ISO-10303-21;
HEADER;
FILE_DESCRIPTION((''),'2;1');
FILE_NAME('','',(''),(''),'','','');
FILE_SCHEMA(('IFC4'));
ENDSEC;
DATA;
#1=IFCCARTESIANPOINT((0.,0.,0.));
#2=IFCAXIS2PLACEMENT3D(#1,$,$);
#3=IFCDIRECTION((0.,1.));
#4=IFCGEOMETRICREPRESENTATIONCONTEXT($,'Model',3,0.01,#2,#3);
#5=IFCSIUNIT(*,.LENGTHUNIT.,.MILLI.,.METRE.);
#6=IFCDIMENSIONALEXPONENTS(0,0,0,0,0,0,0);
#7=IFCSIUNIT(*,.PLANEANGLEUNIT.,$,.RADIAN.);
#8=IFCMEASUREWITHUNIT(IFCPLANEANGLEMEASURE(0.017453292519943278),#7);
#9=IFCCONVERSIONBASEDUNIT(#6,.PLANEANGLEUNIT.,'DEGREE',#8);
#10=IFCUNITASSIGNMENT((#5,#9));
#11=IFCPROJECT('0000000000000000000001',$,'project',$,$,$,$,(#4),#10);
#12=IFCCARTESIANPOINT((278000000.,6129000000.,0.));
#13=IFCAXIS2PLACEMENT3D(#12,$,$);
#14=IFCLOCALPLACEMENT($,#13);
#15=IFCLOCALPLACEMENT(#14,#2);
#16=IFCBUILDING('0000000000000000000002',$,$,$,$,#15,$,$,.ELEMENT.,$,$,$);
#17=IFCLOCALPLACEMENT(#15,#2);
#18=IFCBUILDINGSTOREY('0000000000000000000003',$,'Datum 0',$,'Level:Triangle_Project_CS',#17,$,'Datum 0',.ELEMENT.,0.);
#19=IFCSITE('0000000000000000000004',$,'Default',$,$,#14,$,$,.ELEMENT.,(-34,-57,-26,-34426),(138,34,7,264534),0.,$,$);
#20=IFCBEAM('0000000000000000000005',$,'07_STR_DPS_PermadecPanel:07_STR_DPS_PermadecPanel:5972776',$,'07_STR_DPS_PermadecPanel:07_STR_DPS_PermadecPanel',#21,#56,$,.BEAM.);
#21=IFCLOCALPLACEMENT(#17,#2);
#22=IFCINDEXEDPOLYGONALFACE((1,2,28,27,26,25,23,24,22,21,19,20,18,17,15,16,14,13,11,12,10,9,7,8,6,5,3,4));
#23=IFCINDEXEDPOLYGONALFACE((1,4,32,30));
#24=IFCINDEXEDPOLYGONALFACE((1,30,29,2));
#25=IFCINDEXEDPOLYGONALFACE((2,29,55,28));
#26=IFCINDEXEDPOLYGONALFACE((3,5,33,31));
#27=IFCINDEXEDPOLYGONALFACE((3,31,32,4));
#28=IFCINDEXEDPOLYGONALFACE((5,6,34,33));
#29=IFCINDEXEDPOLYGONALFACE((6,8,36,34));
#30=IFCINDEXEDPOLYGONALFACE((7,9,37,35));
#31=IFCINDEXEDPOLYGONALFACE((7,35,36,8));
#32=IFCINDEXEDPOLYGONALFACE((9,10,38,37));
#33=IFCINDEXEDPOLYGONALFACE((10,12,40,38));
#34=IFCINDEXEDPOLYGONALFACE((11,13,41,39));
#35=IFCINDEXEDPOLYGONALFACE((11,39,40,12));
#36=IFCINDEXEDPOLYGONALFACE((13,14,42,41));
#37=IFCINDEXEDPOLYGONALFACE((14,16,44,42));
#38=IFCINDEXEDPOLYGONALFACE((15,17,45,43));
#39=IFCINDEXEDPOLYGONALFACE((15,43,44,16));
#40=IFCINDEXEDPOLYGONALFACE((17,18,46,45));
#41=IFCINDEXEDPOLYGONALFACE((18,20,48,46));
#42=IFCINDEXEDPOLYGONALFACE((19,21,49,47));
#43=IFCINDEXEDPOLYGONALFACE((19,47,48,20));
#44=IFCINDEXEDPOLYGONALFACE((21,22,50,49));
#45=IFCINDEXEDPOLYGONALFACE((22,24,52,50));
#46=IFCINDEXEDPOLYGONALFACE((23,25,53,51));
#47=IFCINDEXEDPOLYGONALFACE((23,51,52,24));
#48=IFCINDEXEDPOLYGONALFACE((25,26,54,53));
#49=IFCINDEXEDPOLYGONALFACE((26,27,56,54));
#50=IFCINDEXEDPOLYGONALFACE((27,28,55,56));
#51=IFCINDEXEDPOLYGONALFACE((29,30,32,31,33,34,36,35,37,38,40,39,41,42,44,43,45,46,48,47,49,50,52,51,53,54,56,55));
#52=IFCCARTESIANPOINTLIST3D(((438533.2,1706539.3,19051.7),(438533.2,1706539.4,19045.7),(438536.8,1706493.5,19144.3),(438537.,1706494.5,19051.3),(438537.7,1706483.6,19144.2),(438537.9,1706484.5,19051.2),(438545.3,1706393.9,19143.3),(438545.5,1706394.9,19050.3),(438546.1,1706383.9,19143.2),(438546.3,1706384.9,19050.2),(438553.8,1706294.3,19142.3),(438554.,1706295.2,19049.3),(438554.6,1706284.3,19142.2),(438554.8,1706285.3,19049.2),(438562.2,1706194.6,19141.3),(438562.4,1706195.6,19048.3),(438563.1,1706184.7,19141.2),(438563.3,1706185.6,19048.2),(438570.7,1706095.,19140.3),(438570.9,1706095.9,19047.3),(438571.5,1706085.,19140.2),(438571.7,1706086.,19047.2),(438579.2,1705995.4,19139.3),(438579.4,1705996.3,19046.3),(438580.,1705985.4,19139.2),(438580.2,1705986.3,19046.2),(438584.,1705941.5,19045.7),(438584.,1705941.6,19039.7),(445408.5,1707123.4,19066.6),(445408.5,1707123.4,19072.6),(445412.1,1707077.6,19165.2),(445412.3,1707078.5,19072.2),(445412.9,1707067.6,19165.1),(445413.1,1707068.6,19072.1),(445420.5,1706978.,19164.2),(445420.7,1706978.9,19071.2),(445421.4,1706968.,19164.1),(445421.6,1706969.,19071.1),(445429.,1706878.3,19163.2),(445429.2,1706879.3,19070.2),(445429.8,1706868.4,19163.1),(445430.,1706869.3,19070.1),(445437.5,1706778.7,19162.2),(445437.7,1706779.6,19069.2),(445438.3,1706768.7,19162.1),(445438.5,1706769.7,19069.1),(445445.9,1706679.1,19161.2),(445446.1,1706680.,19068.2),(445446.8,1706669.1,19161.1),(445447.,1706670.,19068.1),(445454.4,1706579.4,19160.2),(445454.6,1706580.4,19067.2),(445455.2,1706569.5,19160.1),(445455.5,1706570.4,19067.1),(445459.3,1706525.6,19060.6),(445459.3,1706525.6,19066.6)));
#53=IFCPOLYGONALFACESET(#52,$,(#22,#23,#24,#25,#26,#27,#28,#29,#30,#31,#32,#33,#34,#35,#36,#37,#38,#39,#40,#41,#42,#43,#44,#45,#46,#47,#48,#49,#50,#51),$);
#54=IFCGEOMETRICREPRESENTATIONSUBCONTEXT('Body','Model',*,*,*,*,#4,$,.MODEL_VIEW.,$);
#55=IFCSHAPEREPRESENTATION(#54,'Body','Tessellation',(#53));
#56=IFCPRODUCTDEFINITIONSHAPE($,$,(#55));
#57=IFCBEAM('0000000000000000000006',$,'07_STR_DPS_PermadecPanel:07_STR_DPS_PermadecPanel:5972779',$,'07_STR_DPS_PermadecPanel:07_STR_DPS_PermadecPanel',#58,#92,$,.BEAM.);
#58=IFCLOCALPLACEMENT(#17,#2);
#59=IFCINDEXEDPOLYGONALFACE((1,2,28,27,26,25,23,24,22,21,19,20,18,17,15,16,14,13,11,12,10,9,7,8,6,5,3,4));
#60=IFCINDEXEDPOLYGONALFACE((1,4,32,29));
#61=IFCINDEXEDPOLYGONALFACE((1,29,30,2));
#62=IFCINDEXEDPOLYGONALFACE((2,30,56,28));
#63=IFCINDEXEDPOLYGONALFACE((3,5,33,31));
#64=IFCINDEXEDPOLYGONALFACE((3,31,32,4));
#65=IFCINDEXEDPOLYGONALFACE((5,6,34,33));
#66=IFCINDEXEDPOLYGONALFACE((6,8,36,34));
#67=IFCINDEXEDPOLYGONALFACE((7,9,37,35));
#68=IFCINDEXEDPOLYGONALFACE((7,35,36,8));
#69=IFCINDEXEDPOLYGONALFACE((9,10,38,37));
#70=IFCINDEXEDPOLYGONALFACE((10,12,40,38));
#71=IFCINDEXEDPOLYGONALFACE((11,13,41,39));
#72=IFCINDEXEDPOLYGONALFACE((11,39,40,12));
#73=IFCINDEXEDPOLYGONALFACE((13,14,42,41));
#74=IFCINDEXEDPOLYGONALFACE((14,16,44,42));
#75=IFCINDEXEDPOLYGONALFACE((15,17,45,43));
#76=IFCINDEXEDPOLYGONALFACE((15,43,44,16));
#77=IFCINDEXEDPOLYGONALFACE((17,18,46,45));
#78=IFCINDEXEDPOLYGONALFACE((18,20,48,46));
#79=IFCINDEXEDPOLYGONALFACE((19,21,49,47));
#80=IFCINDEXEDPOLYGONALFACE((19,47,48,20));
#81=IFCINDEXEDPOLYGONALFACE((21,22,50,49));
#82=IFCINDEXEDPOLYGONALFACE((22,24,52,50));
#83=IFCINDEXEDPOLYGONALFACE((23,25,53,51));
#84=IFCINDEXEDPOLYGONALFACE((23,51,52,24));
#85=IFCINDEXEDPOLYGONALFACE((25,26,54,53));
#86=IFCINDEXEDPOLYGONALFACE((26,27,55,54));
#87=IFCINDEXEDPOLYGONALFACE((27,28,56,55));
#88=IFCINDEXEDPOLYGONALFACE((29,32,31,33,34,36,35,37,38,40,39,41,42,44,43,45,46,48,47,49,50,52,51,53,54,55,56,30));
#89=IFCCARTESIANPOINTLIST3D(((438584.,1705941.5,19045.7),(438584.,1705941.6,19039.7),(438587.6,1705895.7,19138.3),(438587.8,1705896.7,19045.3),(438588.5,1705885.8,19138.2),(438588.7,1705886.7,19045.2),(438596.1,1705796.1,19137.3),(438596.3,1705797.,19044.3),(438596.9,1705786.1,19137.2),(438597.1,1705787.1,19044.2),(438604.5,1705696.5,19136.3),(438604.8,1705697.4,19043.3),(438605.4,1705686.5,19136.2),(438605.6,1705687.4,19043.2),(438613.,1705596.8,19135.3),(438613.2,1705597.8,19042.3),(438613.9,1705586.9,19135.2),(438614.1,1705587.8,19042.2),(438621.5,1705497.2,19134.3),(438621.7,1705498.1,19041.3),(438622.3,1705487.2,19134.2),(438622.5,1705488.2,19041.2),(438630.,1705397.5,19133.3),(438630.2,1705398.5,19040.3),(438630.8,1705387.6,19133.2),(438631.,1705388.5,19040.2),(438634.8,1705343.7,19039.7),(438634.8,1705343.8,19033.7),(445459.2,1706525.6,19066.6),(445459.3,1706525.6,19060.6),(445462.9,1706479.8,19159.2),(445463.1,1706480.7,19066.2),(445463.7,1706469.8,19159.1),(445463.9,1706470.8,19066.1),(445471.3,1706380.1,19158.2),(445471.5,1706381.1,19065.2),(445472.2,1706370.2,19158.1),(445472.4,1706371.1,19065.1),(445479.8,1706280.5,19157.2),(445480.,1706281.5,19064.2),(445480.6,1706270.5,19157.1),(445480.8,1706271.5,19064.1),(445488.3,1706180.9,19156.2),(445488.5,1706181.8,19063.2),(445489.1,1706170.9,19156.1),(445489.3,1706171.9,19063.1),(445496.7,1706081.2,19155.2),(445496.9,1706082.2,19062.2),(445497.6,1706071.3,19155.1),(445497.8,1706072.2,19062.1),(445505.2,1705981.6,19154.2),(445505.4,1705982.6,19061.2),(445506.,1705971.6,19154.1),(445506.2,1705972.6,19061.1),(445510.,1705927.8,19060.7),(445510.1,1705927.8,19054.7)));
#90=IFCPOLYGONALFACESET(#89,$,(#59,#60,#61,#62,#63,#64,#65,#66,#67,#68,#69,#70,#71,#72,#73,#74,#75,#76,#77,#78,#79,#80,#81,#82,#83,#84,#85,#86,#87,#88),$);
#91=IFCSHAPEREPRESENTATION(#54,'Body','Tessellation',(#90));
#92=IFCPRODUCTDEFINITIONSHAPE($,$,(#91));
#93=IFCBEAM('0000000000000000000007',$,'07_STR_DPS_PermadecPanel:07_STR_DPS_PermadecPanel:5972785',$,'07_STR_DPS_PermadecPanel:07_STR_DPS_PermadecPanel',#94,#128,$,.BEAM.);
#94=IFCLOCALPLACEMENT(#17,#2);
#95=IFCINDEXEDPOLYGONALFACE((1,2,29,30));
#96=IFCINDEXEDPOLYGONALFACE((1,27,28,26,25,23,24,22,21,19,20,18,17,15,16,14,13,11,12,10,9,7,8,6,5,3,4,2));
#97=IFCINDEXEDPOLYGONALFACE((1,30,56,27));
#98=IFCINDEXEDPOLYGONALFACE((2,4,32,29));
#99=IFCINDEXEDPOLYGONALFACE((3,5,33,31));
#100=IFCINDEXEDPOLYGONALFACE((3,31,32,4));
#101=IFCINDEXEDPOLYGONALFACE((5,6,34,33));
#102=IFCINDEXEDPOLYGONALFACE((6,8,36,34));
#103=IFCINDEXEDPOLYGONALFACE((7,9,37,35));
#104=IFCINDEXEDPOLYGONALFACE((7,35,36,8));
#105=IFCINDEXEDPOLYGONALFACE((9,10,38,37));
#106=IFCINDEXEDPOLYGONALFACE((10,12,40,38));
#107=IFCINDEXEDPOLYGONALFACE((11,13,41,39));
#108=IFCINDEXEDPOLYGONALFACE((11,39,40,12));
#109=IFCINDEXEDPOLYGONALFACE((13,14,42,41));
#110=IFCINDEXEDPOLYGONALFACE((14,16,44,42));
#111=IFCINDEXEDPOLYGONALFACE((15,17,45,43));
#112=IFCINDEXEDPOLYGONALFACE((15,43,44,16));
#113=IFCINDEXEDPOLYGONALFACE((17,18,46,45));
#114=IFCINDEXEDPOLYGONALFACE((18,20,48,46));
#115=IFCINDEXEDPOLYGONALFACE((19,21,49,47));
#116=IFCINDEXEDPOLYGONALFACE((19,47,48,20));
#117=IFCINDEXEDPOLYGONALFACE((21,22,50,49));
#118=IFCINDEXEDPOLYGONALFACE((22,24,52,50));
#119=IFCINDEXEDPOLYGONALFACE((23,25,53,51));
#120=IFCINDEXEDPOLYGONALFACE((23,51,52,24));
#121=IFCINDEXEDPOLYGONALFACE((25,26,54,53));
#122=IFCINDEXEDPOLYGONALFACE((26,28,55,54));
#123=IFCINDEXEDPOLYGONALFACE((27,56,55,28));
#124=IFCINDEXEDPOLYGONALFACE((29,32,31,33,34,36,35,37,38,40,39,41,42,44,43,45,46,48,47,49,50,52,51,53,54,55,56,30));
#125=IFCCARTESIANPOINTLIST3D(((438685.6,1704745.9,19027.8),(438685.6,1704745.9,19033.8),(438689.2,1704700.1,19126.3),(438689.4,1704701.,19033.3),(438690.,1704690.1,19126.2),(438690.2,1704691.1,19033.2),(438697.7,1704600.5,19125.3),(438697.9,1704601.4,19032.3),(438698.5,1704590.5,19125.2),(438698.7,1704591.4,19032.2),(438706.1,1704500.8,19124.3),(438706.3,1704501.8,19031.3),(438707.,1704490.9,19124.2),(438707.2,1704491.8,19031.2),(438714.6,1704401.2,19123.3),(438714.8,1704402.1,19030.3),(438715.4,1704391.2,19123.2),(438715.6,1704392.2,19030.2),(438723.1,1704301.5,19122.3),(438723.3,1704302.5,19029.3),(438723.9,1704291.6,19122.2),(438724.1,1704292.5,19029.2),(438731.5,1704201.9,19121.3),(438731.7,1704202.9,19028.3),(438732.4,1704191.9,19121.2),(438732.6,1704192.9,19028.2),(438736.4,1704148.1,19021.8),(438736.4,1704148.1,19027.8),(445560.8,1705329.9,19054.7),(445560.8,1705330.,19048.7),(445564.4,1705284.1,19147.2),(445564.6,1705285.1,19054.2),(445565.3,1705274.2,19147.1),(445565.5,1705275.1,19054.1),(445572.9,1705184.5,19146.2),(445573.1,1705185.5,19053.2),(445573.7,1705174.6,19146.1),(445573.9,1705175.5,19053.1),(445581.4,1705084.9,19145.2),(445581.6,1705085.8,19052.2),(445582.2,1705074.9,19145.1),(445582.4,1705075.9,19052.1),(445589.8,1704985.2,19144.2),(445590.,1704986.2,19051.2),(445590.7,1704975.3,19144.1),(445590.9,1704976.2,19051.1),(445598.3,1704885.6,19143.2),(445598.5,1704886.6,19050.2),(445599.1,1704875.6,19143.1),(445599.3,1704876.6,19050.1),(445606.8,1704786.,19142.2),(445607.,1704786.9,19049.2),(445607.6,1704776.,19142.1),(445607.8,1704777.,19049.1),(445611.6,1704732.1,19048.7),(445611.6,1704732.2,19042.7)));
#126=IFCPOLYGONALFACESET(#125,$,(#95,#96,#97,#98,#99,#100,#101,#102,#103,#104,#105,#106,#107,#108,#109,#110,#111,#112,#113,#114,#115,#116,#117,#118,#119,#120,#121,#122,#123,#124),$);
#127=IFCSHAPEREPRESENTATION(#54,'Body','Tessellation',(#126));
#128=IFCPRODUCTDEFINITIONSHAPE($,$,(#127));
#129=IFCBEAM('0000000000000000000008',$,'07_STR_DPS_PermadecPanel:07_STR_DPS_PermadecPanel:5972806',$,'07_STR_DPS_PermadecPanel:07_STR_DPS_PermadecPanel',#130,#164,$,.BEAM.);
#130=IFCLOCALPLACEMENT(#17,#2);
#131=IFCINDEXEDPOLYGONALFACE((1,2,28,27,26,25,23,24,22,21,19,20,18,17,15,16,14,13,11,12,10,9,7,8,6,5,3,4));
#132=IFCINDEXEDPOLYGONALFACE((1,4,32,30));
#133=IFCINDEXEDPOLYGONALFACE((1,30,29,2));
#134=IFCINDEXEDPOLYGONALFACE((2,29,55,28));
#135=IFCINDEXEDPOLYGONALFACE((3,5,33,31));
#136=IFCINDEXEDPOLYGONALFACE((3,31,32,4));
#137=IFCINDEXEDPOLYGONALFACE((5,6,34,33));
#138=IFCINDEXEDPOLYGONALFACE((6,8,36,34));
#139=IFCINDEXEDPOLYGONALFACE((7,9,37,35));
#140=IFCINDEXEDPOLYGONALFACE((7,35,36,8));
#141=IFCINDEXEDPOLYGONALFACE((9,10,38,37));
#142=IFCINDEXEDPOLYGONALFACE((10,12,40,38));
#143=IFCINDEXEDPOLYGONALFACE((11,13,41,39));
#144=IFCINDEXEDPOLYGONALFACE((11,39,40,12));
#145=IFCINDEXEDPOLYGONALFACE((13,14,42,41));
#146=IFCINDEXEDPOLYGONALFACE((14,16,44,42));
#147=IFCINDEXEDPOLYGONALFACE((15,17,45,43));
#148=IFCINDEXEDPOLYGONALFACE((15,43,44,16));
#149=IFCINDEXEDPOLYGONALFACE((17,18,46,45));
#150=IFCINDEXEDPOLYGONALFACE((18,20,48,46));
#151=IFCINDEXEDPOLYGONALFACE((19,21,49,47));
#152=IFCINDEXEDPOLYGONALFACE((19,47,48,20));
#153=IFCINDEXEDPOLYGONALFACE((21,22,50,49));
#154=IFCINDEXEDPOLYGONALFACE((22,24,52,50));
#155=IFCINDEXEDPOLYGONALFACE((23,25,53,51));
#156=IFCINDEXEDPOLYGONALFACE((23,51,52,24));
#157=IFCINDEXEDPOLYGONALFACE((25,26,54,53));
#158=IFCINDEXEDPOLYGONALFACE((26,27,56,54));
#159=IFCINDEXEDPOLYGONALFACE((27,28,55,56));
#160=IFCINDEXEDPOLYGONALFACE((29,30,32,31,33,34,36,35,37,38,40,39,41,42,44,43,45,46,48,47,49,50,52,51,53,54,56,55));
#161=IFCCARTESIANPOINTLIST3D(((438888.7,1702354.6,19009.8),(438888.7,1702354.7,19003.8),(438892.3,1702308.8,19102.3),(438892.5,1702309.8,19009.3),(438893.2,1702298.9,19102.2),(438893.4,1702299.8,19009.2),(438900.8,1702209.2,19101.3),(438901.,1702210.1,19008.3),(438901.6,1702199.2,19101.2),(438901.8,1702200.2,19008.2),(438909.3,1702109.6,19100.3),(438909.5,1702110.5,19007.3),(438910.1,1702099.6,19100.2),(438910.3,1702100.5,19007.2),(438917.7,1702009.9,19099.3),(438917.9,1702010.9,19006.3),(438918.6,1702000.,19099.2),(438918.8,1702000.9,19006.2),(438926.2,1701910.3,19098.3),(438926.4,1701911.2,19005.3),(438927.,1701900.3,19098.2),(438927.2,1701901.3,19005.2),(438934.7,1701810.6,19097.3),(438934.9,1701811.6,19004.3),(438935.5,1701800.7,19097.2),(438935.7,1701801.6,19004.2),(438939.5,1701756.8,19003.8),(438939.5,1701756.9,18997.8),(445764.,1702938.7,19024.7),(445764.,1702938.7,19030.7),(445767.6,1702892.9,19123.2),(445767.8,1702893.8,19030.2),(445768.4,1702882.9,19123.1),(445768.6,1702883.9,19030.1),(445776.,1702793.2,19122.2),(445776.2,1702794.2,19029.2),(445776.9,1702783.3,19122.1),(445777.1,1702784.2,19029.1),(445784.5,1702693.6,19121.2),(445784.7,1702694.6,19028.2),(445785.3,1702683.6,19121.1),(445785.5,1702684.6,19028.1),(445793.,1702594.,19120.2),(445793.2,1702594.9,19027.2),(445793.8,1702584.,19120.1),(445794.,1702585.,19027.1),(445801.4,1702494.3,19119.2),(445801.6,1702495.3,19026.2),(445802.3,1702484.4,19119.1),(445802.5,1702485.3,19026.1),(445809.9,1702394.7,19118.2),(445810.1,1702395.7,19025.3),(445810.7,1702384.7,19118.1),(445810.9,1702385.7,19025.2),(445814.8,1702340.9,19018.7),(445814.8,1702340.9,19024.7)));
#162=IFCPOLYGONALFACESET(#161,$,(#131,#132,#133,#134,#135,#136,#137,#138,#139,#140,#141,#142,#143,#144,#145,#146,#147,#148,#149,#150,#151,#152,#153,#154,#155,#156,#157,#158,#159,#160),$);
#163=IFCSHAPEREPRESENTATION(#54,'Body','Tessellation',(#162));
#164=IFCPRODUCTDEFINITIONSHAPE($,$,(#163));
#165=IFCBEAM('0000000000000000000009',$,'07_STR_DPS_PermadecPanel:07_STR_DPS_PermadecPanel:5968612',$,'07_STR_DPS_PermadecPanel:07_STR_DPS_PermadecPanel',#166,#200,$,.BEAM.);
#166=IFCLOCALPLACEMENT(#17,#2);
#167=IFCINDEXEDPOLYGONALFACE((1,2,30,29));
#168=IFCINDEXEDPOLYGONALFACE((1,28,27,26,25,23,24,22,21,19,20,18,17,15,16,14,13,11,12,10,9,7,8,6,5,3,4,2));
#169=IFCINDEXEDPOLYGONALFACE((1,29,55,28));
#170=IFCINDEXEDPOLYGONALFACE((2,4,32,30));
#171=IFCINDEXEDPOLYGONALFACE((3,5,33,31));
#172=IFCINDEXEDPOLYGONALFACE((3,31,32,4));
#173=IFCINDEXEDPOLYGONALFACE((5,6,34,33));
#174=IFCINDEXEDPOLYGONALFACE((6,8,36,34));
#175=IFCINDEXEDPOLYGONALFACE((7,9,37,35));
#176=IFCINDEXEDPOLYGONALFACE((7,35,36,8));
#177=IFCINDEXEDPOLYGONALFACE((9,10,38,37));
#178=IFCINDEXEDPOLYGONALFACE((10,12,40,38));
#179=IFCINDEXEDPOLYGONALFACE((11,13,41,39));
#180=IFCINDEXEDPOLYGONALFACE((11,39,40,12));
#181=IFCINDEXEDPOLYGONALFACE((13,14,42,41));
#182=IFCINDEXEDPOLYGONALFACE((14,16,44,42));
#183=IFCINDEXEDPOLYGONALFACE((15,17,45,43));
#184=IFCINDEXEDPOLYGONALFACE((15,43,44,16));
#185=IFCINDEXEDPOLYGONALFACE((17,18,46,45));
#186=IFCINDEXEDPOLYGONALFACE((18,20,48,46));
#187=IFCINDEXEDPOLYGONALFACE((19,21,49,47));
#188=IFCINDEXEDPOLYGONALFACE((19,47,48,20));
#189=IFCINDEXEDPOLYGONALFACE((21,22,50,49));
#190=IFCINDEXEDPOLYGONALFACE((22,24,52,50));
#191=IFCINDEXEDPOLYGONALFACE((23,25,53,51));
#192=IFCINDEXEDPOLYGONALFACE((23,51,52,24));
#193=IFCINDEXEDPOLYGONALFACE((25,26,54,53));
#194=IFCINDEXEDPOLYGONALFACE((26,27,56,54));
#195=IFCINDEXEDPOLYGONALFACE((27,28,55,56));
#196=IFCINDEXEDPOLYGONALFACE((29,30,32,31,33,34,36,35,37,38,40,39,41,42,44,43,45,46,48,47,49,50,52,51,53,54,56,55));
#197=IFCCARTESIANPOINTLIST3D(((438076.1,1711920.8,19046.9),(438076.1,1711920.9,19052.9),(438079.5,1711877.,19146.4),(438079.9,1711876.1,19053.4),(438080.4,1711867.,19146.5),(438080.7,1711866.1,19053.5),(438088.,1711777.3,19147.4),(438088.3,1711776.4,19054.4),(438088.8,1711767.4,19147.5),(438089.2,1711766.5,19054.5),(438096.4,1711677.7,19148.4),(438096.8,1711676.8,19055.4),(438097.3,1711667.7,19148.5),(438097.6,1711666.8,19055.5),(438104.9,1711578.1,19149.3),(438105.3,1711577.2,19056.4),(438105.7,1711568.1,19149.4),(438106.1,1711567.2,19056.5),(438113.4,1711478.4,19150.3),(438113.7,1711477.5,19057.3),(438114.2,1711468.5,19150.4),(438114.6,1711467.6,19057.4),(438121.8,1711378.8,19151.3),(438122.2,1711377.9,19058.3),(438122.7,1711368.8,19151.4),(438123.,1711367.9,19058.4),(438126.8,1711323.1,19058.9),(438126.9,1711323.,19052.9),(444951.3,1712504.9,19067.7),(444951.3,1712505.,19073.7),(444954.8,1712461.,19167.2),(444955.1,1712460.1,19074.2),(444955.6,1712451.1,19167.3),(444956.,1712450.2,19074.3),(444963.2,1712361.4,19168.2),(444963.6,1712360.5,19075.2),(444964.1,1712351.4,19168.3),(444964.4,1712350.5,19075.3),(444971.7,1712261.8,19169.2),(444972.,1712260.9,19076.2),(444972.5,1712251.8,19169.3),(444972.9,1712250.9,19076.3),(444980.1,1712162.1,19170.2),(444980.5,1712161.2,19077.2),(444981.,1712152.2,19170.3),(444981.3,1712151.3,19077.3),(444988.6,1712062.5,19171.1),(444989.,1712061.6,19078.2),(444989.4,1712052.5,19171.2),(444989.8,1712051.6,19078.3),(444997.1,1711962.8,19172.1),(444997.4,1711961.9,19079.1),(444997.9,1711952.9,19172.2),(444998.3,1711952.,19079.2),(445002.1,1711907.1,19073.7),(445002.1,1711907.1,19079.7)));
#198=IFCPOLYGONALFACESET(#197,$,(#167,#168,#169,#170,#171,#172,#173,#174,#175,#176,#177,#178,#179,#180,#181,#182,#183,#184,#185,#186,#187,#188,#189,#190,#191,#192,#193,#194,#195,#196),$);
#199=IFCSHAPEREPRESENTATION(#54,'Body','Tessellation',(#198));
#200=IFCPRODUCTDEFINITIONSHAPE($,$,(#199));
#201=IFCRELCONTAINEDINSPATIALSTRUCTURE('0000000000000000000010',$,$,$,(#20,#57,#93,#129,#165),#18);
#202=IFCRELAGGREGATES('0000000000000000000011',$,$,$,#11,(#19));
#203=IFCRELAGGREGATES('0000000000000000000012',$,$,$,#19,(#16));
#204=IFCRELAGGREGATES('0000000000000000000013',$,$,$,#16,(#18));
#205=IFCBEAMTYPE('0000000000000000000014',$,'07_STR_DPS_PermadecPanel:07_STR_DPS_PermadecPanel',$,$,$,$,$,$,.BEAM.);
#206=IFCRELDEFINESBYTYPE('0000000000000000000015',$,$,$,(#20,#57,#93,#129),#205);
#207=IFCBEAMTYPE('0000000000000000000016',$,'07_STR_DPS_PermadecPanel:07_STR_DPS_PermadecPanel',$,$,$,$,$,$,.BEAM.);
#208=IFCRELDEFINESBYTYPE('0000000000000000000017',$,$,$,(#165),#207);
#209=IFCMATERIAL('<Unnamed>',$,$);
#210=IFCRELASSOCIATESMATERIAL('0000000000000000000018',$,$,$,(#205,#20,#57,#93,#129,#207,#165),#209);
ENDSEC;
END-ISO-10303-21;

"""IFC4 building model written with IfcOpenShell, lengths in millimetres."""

from ifc_helpers import new_model, entity, si_unit, converted_unit, direction, frame, origin, place, context, subcontext, project, spatial, indexed_curve, outline, extrude, source, transform, mapped, material, type_object, type_shapes, element, save


model = new_model("IFC4")

# Units and contexts
model_context = context("Model", 3, precision=0.01, world=origin(), true_north=direction((0.0, 1.0)))
body_context = subcontext(model_context, "Body", "Model", "MODEL_VIEW")
ifc_project = project(units=[si_unit("LENGTHUNIT", "METRE", prefix="MILLI"), converted_unit("PLANEANGLEUNIT", "DEGREE", entity("IfcPlaneAngleMeasure", 0.017453292519943278), si_unit("PLANEANGLEUNIT", "RADIAN"), dimensions=[0, 0, 0, 0, 0, 0, 0])], contexts=[model_context])

# Site, building, storey
site_placement = place(None, frame((278000000.0, 6129000000.0, 0.0)))
site = spatial("IfcSite", under=ifc_project, at=site_placement, Name="Default", CompositionType="ELEMENT", RefLatitude=(-34, -57, -26, -34426), RefLongitude=(138, 34, 7, 264534), RefElevation=0.0)
building_placement = place(site_placement, origin())
building = spatial("IfcBuilding", under=site, at=building_placement, CompositionType="ELEMENT")
storey_placement = place(building_placement, frame((0.0, 0.0, 0.0)))
storey = spatial("IfcBuildingStorey", under=building, at=storey_placement, Name="Datum 0", ObjectType="Level:Triangle_Project_CS", LongName="Datum 0", CompositionType="ELEMENT", Elevation=0.0)

# Beams
ifc_material = material(Name="<Unnamed>")
beam_type_1 = type_object("IfcBeamType", Name="07_STR_DPS_PermadecPanel:07_STR_DPS_PermadecPanel", PredefinedType="BEAM", material=ifc_material)
shared_shape_1 = source(origin(), body_context, "Body", "SweptSolid", [
    extrude(outline(indexed_curve([(-300.0, -45.4), (300.0, -45.4), (300.0, -39.4), (255.0, -39.4), (255.0, 53.6), (245.0, 53.6), (245.0, -39.4), (155.0, -39.4), (155.0, 53.6), (145.0, 53.6), (145.0, -39.4), (55.0, -39.4), (55.0, 53.6), (45.0, 53.6), (45.0, -39.4), (-45.0, -39.4), (-45.0, 53.6), (-55.0, 53.6), (-55.0, -39.4), (-145.0, -39.4), (-145.0, 53.6), (-155.0, 53.6), (-155.0, -39.4), (-245.0, -39.4), (-245.0, 53.6), (-255.0, 53.6), (-255.0, -39.4), (-300.0, -39.4), (-300.0, -45.4)], self_intersect=False)), frame((-3450.0, 0.0, 45.4), z_axis=(1.0, 0.0, 0.0), x_axis=(0.0, 1.0, 0.0)), (0.0, 0.0, 1.0), 6900.0),
])
type_shapes(beam_type_1, [shared_shape_1])
for number, where, z_axis, x_axis, name in (
    (1, (441996.3, 1706532.5, 19053.2), (-0.002173, -0.010208, 0.999946), (-0.996406, -0.084646, -0.00303), "07_STR_DPS_PermadecPanel:07_STR_DPS_PermadecPanel:5972776"),
    (2, (442047.0, 1705934.7, 19047.2), (-0.002173, -0.010208, 0.999946), (-0.996406, -0.084646, -0.00303), "07_STR_DPS_PermadecPanel:07_STR_DPS_PermadecPanel:5972779"),
    (3, (442148.6, 1704739.1, 19035.2), (-0.002173, -0.010208, 0.999946), (-0.996406, -0.084646, -0.00303), "07_STR_DPS_PermadecPanel:07_STR_DPS_PermadecPanel:5972785"),
    (4, (442351.8, 1702347.8, 19011.2), (-0.002173, -0.010208, 0.999946), (-0.996406, -0.084646, -0.00303), "07_STR_DPS_PermadecPanel:07_STR_DPS_PermadecPanel:5972806"),
):
    element("IfcBeam", number, at=place(storey_placement, frame(where, z_axis=z_axis, x_axis=x_axis)), inside=storey, type_object=beam_type_1, material=ifc_material, Name=name, ObjectType="07_STR_DPS_PermadecPanel:07_STR_DPS_PermadecPanel", PredefinedType="BEAM", context=body_context, shape_type="MappedRepresentation", body=[
        mapped(shared_shape_1, transform((0.0, 0.0, 0.0), scale=1.0)),
    ])
beam_type_2 = type_object("IfcBeamType", Name="07_STR_DPS_PermadecPanel:07_STR_DPS_PermadecPanel", PredefinedType="BEAM", material=ifc_material)
shared_shape_2 = source(origin(), body_context, "Body", "SweptSolid", [
    extrude(outline(indexed_curve([(-300.0, -45.4), (300.0, -45.4), (300.0, -39.4), (255.0, -39.4), (255.0, 53.6), (245.0, 53.6), (245.0, -39.4), (155.0, -39.4), (155.0, 53.6), (145.0, 53.6), (145.0, -39.4), (55.0, -39.4), (55.0, 53.6), (45.0, 53.6), (45.0, -39.4), (-45.0, -39.4), (-45.0, 53.6), (-55.0, 53.6), (-55.0, -39.4), (-145.0, -39.4), (-145.0, 53.6), (-155.0, 53.6), (-155.0, -39.4), (-245.0, -39.4), (-245.0, 53.6), (-255.0, 53.6), (-255.0, -39.4), (-300.0, -39.4), (-300.0, -45.4)], self_intersect=False)), frame((-3450.0, 0.0, 45.4), z_axis=(1.0, 0.0, 0.0), x_axis=(0.0, 1.0, 0.0)), (0.0, 0.0, 1.0), 6900.0),
])
type_shapes(beam_type_2, [shared_shape_2])
for number, where, z_axis, x_axis, name in (
    (5, (441539.1, 1711914.0, 19060.3), (-0.003847, 0.009662, 0.999946), (-0.996407, -0.084646, -0.003015), "07_STR_DPS_PermadecPanel:07_STR_DPS_PermadecPanel:5968612"),
):
    element("IfcBeam", number, at=place(storey_placement, frame(where, z_axis=z_axis, x_axis=x_axis)), inside=storey, type_object=beam_type_2, material=ifc_material, Name=name, ObjectType="07_STR_DPS_PermadecPanel:07_STR_DPS_PermadecPanel", PredefinedType="BEAM", context=body_context, shape_type="MappedRepresentation", body=[
        mapped(shared_shape_2, transform((0.0, 0.0, 0.0), scale=1.0)),
    ])

save(model, "model.ifc")
